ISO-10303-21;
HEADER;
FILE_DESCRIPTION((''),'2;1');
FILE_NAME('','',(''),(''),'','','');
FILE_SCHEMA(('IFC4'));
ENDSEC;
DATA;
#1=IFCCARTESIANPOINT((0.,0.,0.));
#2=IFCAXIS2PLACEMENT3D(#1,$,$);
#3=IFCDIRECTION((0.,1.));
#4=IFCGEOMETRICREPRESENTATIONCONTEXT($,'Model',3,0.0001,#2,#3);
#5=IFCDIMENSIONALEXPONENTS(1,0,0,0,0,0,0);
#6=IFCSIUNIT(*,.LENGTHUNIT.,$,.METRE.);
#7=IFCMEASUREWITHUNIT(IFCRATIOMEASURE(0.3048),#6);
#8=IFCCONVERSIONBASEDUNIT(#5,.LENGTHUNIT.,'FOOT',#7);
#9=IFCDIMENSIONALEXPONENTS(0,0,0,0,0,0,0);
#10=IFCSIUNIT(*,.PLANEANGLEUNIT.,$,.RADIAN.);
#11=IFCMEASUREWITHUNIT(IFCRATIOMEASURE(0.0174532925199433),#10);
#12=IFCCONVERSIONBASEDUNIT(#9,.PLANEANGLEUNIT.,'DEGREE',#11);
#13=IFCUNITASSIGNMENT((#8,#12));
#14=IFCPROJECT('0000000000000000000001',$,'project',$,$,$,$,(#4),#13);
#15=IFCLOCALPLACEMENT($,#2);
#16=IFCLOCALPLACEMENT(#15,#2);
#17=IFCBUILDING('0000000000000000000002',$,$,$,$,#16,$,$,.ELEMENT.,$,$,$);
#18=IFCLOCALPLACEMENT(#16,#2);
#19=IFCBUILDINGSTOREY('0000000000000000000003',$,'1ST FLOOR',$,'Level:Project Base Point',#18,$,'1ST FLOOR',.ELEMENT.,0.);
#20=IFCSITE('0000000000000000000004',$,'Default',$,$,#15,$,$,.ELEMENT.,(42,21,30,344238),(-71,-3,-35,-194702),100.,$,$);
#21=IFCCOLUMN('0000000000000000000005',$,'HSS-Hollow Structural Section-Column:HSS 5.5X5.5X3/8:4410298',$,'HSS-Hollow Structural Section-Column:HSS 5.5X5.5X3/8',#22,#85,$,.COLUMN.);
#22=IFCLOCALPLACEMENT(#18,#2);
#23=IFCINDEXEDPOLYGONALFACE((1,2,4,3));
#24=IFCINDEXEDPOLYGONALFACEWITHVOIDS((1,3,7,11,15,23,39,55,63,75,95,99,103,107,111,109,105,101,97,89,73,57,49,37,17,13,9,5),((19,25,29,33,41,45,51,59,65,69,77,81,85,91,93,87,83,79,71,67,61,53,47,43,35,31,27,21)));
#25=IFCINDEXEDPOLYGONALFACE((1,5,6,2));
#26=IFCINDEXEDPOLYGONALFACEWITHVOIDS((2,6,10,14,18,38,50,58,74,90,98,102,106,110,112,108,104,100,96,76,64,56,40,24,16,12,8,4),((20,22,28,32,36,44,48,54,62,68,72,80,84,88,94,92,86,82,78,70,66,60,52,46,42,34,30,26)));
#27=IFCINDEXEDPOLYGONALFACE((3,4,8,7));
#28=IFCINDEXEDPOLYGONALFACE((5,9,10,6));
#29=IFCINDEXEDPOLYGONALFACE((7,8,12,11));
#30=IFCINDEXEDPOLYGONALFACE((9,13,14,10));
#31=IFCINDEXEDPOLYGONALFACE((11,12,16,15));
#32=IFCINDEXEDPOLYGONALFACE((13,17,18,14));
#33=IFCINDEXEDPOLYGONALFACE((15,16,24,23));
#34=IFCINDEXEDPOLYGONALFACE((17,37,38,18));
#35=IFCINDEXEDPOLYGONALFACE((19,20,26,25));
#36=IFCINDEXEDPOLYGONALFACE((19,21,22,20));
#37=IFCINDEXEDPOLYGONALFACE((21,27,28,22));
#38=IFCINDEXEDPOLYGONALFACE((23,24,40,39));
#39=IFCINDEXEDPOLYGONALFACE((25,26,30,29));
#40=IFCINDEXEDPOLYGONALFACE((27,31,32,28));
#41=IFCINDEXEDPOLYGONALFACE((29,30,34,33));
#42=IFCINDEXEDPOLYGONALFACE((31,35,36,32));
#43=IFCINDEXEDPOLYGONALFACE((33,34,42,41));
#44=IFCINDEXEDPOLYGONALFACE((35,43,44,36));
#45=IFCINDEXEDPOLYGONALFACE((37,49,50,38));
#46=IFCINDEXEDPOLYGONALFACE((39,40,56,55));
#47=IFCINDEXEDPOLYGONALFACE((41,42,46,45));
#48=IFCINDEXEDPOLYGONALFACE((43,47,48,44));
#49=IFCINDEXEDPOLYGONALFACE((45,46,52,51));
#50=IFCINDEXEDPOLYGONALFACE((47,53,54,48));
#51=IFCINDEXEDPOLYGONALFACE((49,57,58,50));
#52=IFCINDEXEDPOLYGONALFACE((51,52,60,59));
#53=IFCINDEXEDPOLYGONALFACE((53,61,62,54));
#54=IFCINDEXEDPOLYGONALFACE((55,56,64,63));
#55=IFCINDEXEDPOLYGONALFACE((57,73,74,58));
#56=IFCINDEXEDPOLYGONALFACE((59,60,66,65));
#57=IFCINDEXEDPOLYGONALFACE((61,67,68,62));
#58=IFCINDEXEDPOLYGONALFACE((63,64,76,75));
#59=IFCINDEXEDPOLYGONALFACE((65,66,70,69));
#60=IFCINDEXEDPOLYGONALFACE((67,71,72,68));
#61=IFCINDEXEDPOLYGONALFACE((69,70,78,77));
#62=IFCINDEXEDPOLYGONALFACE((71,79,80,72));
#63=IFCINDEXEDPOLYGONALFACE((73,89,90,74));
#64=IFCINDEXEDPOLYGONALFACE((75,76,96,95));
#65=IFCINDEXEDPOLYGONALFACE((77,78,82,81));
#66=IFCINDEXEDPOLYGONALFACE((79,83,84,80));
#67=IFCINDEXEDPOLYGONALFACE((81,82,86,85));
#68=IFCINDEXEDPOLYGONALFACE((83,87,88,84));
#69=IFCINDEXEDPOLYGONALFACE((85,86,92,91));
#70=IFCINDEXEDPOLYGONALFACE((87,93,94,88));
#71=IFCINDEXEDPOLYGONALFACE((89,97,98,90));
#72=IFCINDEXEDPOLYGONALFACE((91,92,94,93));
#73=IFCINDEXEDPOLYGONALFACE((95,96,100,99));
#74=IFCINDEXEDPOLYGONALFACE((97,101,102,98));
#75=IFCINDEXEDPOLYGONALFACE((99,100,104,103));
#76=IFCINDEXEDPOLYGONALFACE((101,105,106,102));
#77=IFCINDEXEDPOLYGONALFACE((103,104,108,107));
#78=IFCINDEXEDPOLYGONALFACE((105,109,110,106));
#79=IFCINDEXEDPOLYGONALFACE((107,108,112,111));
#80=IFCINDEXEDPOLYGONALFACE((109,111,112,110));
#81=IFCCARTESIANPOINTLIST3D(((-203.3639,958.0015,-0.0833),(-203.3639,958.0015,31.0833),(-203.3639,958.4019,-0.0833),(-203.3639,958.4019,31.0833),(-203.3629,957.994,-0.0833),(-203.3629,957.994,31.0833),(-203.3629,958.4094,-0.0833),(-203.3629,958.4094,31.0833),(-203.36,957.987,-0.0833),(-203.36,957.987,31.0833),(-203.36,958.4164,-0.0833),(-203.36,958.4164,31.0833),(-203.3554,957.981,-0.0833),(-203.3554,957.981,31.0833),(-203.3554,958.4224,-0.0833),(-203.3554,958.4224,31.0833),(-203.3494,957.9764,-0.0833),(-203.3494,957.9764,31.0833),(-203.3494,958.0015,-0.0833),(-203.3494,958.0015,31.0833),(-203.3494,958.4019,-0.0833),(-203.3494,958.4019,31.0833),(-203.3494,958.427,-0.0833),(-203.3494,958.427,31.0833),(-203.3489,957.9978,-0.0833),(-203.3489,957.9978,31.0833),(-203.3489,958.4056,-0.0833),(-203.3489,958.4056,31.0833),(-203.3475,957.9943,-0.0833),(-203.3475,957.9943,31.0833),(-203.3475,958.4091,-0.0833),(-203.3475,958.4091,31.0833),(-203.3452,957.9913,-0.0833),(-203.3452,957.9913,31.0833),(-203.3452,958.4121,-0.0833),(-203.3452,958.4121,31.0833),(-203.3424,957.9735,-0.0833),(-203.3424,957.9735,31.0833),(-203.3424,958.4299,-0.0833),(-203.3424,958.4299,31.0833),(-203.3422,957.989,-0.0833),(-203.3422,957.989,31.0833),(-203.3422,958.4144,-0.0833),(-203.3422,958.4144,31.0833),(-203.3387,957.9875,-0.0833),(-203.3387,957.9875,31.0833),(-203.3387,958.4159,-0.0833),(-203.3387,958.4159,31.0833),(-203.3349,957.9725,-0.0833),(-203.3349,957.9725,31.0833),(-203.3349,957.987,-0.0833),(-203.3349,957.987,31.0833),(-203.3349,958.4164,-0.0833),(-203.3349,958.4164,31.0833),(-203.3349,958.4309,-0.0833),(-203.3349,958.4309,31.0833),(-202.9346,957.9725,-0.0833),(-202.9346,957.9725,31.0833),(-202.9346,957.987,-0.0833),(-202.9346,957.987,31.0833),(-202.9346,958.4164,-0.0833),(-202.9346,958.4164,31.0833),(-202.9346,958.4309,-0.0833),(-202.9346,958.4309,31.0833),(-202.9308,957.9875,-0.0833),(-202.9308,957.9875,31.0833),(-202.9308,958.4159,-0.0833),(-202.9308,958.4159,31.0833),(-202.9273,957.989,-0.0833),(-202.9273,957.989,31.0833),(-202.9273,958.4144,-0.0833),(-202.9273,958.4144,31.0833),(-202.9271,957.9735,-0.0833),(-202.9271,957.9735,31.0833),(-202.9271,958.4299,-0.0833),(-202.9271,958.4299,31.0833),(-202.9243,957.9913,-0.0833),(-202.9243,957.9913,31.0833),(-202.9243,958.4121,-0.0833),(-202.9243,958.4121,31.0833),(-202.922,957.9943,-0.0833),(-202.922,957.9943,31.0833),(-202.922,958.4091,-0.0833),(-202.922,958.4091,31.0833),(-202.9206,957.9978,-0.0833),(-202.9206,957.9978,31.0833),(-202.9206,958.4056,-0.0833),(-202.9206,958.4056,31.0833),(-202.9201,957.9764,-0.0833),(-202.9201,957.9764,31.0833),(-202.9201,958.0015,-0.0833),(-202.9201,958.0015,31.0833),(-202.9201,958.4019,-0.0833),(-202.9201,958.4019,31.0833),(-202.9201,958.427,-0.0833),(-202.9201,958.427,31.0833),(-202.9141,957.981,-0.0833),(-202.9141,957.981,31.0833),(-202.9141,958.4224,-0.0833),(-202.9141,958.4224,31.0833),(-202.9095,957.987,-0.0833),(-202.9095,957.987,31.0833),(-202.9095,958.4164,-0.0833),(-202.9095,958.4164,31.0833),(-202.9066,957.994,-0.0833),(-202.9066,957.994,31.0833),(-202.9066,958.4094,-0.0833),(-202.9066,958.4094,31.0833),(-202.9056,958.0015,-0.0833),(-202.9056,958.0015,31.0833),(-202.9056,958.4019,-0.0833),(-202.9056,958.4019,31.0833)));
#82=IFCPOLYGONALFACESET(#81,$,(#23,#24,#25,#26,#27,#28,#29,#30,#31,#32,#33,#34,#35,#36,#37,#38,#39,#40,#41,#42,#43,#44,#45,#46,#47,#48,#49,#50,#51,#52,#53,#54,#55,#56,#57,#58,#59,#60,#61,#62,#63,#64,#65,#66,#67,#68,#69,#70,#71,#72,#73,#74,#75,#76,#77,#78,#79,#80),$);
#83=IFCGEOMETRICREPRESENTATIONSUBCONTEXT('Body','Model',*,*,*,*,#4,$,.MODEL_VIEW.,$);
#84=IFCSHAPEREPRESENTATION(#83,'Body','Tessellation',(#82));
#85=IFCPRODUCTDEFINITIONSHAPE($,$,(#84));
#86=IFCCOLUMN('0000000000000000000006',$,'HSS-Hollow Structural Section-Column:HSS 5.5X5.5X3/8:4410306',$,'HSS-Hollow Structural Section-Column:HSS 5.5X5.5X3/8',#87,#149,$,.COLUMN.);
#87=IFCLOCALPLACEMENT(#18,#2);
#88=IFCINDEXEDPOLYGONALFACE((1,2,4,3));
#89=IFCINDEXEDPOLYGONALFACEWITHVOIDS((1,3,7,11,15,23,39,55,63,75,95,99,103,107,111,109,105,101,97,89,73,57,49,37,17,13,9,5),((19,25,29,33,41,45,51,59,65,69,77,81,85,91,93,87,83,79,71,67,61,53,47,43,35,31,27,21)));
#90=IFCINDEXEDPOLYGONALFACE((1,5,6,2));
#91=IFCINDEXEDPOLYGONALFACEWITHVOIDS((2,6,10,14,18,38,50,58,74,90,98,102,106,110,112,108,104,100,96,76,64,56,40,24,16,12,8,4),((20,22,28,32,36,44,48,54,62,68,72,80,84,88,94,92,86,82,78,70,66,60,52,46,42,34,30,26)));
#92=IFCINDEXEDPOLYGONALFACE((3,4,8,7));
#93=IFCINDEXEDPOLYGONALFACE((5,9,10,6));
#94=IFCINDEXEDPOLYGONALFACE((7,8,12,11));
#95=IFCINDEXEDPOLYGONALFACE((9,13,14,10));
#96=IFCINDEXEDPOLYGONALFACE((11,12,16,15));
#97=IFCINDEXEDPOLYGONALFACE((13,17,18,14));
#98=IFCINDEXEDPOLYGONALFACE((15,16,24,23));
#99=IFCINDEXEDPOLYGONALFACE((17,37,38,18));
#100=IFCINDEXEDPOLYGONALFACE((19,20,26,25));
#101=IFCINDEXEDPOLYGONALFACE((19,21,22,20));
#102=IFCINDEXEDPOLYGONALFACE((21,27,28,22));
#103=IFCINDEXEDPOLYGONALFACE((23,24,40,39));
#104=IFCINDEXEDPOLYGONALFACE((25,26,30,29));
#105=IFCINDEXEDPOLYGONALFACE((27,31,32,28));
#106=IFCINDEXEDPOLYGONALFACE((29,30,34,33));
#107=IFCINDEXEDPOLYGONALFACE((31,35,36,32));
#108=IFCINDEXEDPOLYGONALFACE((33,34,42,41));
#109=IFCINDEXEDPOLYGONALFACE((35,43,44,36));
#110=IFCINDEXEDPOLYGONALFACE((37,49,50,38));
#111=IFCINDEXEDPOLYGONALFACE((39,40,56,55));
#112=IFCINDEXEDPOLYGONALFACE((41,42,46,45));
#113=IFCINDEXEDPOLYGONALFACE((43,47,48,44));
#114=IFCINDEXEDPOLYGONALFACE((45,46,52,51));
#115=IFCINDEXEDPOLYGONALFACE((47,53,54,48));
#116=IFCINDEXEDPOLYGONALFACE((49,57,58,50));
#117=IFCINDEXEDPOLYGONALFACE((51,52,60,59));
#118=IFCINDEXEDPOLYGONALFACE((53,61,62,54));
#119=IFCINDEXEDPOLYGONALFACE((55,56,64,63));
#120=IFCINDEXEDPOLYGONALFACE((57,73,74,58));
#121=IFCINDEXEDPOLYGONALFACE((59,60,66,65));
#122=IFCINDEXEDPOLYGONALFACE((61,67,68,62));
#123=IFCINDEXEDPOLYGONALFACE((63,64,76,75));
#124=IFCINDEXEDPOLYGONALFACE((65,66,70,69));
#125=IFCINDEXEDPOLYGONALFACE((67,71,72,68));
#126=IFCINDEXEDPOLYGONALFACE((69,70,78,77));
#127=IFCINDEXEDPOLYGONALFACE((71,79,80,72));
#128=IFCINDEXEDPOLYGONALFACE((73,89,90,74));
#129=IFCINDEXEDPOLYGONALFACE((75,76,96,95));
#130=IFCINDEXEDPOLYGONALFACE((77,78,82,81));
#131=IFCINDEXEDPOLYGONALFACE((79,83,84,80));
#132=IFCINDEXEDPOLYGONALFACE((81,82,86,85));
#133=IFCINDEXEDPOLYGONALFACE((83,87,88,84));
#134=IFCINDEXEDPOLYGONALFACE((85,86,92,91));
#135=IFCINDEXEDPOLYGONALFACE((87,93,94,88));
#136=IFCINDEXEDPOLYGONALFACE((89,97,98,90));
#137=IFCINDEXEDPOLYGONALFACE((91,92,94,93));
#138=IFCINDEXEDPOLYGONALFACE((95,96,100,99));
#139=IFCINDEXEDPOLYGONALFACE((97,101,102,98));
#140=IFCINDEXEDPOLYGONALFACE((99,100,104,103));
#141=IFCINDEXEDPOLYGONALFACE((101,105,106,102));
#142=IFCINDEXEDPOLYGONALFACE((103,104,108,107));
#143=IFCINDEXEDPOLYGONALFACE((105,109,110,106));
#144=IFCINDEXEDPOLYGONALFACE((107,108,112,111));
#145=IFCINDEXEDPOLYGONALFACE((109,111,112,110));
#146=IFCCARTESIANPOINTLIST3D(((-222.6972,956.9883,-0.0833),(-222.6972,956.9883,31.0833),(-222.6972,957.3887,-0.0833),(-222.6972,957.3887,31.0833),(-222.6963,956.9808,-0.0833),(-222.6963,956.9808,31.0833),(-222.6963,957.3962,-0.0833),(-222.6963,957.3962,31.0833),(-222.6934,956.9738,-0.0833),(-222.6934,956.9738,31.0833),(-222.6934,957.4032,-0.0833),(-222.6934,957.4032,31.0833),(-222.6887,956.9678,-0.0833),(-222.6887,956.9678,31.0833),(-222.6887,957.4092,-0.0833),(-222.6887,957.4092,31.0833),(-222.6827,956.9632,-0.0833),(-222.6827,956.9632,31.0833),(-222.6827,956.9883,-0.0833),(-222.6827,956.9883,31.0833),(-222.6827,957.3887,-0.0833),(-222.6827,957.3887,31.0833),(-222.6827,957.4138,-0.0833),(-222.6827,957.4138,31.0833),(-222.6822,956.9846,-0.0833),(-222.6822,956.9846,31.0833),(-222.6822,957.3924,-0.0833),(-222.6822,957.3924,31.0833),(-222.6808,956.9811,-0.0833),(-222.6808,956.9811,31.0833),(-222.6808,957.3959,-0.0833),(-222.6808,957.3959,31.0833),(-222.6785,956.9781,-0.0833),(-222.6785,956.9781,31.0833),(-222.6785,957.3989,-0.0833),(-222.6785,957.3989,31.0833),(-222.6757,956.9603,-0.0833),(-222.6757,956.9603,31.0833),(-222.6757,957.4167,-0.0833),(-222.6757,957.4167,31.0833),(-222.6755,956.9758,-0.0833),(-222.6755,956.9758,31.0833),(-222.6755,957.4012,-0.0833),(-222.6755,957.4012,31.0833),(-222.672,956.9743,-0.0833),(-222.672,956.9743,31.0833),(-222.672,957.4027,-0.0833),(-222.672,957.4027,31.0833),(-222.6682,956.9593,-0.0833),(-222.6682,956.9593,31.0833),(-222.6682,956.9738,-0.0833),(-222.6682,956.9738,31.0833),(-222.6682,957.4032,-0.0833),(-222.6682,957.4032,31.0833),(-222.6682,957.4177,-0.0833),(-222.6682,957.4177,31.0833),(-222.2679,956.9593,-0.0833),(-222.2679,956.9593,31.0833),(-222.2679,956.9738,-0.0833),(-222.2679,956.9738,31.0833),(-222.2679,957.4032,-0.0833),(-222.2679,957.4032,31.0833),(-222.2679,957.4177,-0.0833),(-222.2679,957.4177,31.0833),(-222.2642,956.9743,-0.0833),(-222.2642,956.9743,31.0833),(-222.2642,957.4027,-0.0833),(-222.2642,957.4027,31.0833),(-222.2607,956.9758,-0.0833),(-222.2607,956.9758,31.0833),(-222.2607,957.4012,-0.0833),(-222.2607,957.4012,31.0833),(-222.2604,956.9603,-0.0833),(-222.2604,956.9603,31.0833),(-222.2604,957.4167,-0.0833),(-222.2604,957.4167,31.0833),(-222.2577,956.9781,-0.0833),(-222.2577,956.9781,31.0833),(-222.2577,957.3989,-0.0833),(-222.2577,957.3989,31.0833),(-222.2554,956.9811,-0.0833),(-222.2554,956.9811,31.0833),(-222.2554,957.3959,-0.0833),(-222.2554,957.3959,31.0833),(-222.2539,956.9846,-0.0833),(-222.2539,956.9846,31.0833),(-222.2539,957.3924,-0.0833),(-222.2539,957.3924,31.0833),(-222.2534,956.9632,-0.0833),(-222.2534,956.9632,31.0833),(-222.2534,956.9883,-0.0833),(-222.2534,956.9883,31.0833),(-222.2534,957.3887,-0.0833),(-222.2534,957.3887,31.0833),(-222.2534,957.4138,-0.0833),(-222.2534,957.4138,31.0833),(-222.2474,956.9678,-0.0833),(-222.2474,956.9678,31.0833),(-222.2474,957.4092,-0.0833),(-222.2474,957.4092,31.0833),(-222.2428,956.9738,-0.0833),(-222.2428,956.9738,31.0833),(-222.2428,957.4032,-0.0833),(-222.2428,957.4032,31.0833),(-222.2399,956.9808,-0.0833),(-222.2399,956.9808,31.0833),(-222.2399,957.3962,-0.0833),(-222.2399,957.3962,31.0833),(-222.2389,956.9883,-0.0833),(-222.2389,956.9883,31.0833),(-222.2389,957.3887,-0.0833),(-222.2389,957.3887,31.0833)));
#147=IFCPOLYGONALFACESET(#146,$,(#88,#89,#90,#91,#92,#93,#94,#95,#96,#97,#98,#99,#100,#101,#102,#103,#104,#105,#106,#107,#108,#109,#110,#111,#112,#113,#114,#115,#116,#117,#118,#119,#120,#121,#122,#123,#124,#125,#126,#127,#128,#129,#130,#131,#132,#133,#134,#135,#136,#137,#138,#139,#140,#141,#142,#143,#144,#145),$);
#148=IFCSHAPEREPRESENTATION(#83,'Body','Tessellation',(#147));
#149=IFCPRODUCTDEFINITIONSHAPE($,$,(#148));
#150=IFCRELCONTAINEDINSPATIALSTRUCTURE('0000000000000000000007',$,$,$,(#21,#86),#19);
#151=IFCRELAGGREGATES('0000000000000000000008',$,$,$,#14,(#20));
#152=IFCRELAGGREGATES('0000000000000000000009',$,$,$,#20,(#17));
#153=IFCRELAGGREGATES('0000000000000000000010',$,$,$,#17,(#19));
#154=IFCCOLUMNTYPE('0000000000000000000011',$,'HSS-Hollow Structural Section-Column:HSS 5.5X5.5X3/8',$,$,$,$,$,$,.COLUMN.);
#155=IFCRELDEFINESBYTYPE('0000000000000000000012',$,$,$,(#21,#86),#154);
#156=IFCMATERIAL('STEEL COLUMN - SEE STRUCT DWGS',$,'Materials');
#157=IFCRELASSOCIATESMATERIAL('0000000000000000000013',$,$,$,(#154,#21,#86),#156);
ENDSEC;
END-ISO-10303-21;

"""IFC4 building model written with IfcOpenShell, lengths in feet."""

from ifc_helpers import new_model, entity, si_unit, converted_unit, direction, frame, frame_2d, origin, place, context, subcontext, project, spatial, polyline, circle_curve, parameter, trimmed, segment, composite_curve, outline, extrude, source, transform, mapped, material, material_profile, profile_set, profile_usage, type_object, type_shapes, element, save


model = new_model("IFC4")

# Units and contexts
model_context = context("Model", 3, precision=0.0001, world=origin(), true_north=direction((0.0, 1.0)))
body_context = subcontext(model_context, "Body", "Model", "MODEL_VIEW")
ifc_project = project(units=[converted_unit("LENGTHUNIT", "FOOT", entity("IfcRatioMeasure", 0.3048), si_unit("LENGTHUNIT", "METRE"), dimensions=[1, 0, 0, 0, 0, 0, 0]), converted_unit("PLANEANGLEUNIT", "DEGREE", entity("IfcRatioMeasure", 0.0174532925199433), si_unit("PLANEANGLEUNIT", "RADIAN"), dimensions=[0, 0, 0, 0, 0, 0, 0])], contexts=[model_context])

# Site, building, storey
site_placement = place(None, origin())
site = spatial("IfcSite", under=ifc_project, at=site_placement, Name="Default", CompositionType="ELEMENT", RefLatitude=(42, 21, 30, 344238), RefLongitude=(-71, -3, -35, -194702), RefElevation=100.0)
building_placement = place(site_placement, origin())
building = spatial("IfcBuilding", under=site, at=building_placement, CompositionType="ELEMENT")
storey_placement = place(building_placement, origin())
storey = spatial("IfcBuildingStorey", under=building, at=storey_placement, Name="1ST FLOOR", ObjectType="Level:Project Base Point", LongName="1ST FLOOR", CompositionType="ELEMENT", Elevation=0.0)

# Columns
ifc_material_1 = material(Name="STEEL COLUMN - SEE STRUCT DWGS", Category="Materials")
ifc_material_profile_1 = material_profile(ifc_material_1, outline(composite_curve([segment(trimmed(circle_curve(frame_2d((0.2002, -0.2002), x_axis=(1.0, 0.0)), 0.029), [parameter(270.0)], [parameter(0.0)], True, "PARAMETER"), True, "CONTINUOUS"), segment(polyline([(0.2292, -0.2002), (0.2292, 0.2002)]), True, "CONTINUOUS"), segment(trimmed(circle_curve(frame_2d((0.2002, 0.2002), x_axis=(1.0, 0.0)), 0.029), [parameter(0.0)], [parameter(90.0)], True, "PARAMETER"), True, "CONTINUOUS"), segment(polyline([(0.2002, 0.2292), (-0.2002, 0.2292)]), True, "CONTINUOUS"), segment(trimmed(circle_curve(frame_2d((-0.2002, 0.2002), x_axis=(1.0, 0.0)), 0.029), [parameter(90.0)], [parameter(180.0)], True, "PARAMETER"), True, "CONTINUOUS"), segment(polyline([(-0.2292, 0.2002), (-0.2292, -0.2002)]), True, "CONTINUOUS"), segment(trimmed(circle_curve(frame_2d((-0.2002, -0.2002), x_axis=(1.0, 0.0)), 0.029), [parameter(180.0)], [parameter(270.0)], True, "PARAMETER"), True, "CONTINUOUS"), segment(polyline([(-0.2002, -0.2292), (0.2002, -0.2292)]), True, "CONTINUOUS")], self_intersect=False), holes=[composite_curve([segment(polyline([(0.2002, -0.2147), (-0.2002, -0.2147)]), True, "CONTINUOUS"), segment(trimmed(circle_curve(frame_2d((-0.2002, -0.2002), x_axis=(1.0, 0.0)), 0.0145), [parameter(180.0)], [parameter(270.0)], True, "PARAMETER"), False, "CONTINUOUS"), segment(polyline([(-0.2147, -0.2002), (-0.2147, 0.2002)]), True, "CONTINUOUS"), segment(trimmed(circle_curve(frame_2d((-0.2002, 0.2002), x_axis=(1.0, 0.0)), 0.0145), [parameter(90.0)], [parameter(180.0)], True, "PARAMETER"), False, "CONTINUOUS"), segment(polyline([(-0.2002, 0.2147), (0.2002, 0.2147)]), True, "CONTINUOUS"), segment(trimmed(circle_curve(frame_2d((0.2002, 0.2002), x_axis=(1.0, 0.0)), 0.0145), [parameter(0.0)], [parameter(90.0)], True, "PARAMETER"), False, "CONTINUOUS"), segment(polyline([(0.2147, 0.2002), (0.2147, -0.2002)]), True, "CONTINUOUS"), segment(trimmed(circle_curve(frame_2d((0.2002, -0.2002), x_axis=(1.0, 0.0)), 0.0145), [parameter(270.0)], [parameter(0.0)], True, "PARAMETER"), False, "CONTINUOUS")], self_intersect=False)]), Name="HSS 5.5X5.5X3/8")
ifc_profile_set_1 = profile_set([ifc_material_profile_1], Name="HSS 5.5X5.5X3/8")
ifc_profile_usage_1 = profile_usage(ifc_profile_set_1)
column_type_1 = type_object("IfcColumnType", Name="HSS-Hollow Structural Section-Column:HSS 5.5X5.5X3/8", PredefinedType="COLUMN", material=ifc_profile_set_1)
shared_shape_1 = source(origin(), body_context, "Body", "SweptSolid", [
    extrude(outline(composite_curve([segment(trimmed(circle_curve(frame_2d((0.2002, -0.2002), x_axis=(1.0, 0.0)), 0.029), [parameter(270.0)], [parameter(0.0)], True, "PARAMETER"), True, "CONTINUOUS"), segment(polyline([(0.2292, -0.2002), (0.2292, 0.2002)]), True, "CONTINUOUS"), segment(trimmed(circle_curve(frame_2d((0.2002, 0.2002), x_axis=(1.0, 0.0)), 0.029), [parameter(0.0)], [parameter(90.0)], True, "PARAMETER"), True, "CONTINUOUS"), segment(polyline([(0.2002, 0.2292), (-0.2002, 0.2292)]), True, "CONTINUOUS"), segment(trimmed(circle_curve(frame_2d((-0.2002, 0.2002), x_axis=(1.0, 0.0)), 0.029), [parameter(90.0)], [parameter(180.0)], True, "PARAMETER"), True, "CONTINUOUS"), segment(polyline([(-0.2292, 0.2002), (-0.2292, -0.2002)]), True, "CONTINUOUS"), segment(trimmed(circle_curve(frame_2d((-0.2002, -0.2002), x_axis=(1.0, 0.0)), 0.029), [parameter(180.0)], [parameter(270.0)], True, "PARAMETER"), True, "CONTINUOUS"), segment(polyline([(-0.2002, -0.2292), (0.2002, -0.2292)]), True, "CONTINUOUS")], self_intersect=False), holes=[composite_curve([segment(polyline([(0.2002, -0.2147), (-0.2002, -0.2147)]), True, "CONTINUOUS"), segment(trimmed(circle_curve(frame_2d((-0.2002, -0.2002), x_axis=(1.0, 0.0)), 0.0145), [parameter(180.0)], [parameter(270.0)], True, "PARAMETER"), False, "CONTINUOUS"), segment(polyline([(-0.2147, -0.2002), (-0.2147, 0.2002)]), True, "CONTINUOUS"), segment(trimmed(circle_curve(frame_2d((-0.2002, 0.2002), x_axis=(1.0, 0.0)), 0.0145), [parameter(90.0)], [parameter(180.0)], True, "PARAMETER"), False, "CONTINUOUS"), segment(polyline([(-0.2002, 0.2147), (0.2002, 0.2147)]), True, "CONTINUOUS"), segment(trimmed(circle_curve(frame_2d((0.2002, 0.2002), x_axis=(1.0, 0.0)), 0.0145), [parameter(0.0)], [parameter(90.0)], True, "PARAMETER"), False, "CONTINUOUS"), segment(polyline([(0.2147, 0.2002), (0.2147, -0.2002)]), True, "CONTINUOUS"), segment(trimmed(circle_curve(frame_2d((0.2002, -0.2002), x_axis=(1.0, 0.0)), 0.0145), [parameter(270.0)], [parameter(0.0)], True, "PARAMETER"), False, "CONTINUOUS")], self_intersect=False)]), frame((0.0, 0.0, -0.0833)), (0.0, 0.0, 1.0), 31.1667),
])
type_shapes(column_type_1, [shared_shape_1])
column_1_placement = place(storey_placement, frame((-203.1347, 958.2017, 0.0), z_axis=(0.0, 0.0, 1.0), x_axis=(-1.0, 0.0, 0.0)))
element("IfcColumn", 1, at=column_1_placement, inside=storey, type_object=column_type_1, material=ifc_profile_usage_1, Name="HSS-Hollow Structural Section-Column:HSS 5.5X5.5X3/8:4410298", ObjectType="HSS-Hollow Structural Section-Column:HSS 5.5X5.5X3/8", PredefinedType="COLUMN", context=body_context, shape_type="MappedRepresentation", body=[
    mapped(shared_shape_1, transform((0.0, 0.0, 0.0), scale=1.0)),
])
ifc_profile_usage_2 = profile_usage(ifc_profile_set_1)
column_2_placement = place(storey_placement, frame((-222.4681, 957.1885, 0.0), z_axis=(0.0, 0.0, 1.0), x_axis=(-1.0, 0.0, 0.0)))
element("IfcColumn", 2, at=column_2_placement, inside=storey, type_object=column_type_1, material=ifc_profile_usage_2, Name="HSS-Hollow Structural Section-Column:HSS 5.5X5.5X3/8:4410306", ObjectType="HSS-Hollow Structural Section-Column:HSS 5.5X5.5X3/8", PredefinedType="COLUMN", context=body_context, shape_type="MappedRepresentation", body=[
    mapped(shared_shape_1, transform((0.0, 0.0, 0.0), scale=1.0)),
])

save(model, "model.ifc")
